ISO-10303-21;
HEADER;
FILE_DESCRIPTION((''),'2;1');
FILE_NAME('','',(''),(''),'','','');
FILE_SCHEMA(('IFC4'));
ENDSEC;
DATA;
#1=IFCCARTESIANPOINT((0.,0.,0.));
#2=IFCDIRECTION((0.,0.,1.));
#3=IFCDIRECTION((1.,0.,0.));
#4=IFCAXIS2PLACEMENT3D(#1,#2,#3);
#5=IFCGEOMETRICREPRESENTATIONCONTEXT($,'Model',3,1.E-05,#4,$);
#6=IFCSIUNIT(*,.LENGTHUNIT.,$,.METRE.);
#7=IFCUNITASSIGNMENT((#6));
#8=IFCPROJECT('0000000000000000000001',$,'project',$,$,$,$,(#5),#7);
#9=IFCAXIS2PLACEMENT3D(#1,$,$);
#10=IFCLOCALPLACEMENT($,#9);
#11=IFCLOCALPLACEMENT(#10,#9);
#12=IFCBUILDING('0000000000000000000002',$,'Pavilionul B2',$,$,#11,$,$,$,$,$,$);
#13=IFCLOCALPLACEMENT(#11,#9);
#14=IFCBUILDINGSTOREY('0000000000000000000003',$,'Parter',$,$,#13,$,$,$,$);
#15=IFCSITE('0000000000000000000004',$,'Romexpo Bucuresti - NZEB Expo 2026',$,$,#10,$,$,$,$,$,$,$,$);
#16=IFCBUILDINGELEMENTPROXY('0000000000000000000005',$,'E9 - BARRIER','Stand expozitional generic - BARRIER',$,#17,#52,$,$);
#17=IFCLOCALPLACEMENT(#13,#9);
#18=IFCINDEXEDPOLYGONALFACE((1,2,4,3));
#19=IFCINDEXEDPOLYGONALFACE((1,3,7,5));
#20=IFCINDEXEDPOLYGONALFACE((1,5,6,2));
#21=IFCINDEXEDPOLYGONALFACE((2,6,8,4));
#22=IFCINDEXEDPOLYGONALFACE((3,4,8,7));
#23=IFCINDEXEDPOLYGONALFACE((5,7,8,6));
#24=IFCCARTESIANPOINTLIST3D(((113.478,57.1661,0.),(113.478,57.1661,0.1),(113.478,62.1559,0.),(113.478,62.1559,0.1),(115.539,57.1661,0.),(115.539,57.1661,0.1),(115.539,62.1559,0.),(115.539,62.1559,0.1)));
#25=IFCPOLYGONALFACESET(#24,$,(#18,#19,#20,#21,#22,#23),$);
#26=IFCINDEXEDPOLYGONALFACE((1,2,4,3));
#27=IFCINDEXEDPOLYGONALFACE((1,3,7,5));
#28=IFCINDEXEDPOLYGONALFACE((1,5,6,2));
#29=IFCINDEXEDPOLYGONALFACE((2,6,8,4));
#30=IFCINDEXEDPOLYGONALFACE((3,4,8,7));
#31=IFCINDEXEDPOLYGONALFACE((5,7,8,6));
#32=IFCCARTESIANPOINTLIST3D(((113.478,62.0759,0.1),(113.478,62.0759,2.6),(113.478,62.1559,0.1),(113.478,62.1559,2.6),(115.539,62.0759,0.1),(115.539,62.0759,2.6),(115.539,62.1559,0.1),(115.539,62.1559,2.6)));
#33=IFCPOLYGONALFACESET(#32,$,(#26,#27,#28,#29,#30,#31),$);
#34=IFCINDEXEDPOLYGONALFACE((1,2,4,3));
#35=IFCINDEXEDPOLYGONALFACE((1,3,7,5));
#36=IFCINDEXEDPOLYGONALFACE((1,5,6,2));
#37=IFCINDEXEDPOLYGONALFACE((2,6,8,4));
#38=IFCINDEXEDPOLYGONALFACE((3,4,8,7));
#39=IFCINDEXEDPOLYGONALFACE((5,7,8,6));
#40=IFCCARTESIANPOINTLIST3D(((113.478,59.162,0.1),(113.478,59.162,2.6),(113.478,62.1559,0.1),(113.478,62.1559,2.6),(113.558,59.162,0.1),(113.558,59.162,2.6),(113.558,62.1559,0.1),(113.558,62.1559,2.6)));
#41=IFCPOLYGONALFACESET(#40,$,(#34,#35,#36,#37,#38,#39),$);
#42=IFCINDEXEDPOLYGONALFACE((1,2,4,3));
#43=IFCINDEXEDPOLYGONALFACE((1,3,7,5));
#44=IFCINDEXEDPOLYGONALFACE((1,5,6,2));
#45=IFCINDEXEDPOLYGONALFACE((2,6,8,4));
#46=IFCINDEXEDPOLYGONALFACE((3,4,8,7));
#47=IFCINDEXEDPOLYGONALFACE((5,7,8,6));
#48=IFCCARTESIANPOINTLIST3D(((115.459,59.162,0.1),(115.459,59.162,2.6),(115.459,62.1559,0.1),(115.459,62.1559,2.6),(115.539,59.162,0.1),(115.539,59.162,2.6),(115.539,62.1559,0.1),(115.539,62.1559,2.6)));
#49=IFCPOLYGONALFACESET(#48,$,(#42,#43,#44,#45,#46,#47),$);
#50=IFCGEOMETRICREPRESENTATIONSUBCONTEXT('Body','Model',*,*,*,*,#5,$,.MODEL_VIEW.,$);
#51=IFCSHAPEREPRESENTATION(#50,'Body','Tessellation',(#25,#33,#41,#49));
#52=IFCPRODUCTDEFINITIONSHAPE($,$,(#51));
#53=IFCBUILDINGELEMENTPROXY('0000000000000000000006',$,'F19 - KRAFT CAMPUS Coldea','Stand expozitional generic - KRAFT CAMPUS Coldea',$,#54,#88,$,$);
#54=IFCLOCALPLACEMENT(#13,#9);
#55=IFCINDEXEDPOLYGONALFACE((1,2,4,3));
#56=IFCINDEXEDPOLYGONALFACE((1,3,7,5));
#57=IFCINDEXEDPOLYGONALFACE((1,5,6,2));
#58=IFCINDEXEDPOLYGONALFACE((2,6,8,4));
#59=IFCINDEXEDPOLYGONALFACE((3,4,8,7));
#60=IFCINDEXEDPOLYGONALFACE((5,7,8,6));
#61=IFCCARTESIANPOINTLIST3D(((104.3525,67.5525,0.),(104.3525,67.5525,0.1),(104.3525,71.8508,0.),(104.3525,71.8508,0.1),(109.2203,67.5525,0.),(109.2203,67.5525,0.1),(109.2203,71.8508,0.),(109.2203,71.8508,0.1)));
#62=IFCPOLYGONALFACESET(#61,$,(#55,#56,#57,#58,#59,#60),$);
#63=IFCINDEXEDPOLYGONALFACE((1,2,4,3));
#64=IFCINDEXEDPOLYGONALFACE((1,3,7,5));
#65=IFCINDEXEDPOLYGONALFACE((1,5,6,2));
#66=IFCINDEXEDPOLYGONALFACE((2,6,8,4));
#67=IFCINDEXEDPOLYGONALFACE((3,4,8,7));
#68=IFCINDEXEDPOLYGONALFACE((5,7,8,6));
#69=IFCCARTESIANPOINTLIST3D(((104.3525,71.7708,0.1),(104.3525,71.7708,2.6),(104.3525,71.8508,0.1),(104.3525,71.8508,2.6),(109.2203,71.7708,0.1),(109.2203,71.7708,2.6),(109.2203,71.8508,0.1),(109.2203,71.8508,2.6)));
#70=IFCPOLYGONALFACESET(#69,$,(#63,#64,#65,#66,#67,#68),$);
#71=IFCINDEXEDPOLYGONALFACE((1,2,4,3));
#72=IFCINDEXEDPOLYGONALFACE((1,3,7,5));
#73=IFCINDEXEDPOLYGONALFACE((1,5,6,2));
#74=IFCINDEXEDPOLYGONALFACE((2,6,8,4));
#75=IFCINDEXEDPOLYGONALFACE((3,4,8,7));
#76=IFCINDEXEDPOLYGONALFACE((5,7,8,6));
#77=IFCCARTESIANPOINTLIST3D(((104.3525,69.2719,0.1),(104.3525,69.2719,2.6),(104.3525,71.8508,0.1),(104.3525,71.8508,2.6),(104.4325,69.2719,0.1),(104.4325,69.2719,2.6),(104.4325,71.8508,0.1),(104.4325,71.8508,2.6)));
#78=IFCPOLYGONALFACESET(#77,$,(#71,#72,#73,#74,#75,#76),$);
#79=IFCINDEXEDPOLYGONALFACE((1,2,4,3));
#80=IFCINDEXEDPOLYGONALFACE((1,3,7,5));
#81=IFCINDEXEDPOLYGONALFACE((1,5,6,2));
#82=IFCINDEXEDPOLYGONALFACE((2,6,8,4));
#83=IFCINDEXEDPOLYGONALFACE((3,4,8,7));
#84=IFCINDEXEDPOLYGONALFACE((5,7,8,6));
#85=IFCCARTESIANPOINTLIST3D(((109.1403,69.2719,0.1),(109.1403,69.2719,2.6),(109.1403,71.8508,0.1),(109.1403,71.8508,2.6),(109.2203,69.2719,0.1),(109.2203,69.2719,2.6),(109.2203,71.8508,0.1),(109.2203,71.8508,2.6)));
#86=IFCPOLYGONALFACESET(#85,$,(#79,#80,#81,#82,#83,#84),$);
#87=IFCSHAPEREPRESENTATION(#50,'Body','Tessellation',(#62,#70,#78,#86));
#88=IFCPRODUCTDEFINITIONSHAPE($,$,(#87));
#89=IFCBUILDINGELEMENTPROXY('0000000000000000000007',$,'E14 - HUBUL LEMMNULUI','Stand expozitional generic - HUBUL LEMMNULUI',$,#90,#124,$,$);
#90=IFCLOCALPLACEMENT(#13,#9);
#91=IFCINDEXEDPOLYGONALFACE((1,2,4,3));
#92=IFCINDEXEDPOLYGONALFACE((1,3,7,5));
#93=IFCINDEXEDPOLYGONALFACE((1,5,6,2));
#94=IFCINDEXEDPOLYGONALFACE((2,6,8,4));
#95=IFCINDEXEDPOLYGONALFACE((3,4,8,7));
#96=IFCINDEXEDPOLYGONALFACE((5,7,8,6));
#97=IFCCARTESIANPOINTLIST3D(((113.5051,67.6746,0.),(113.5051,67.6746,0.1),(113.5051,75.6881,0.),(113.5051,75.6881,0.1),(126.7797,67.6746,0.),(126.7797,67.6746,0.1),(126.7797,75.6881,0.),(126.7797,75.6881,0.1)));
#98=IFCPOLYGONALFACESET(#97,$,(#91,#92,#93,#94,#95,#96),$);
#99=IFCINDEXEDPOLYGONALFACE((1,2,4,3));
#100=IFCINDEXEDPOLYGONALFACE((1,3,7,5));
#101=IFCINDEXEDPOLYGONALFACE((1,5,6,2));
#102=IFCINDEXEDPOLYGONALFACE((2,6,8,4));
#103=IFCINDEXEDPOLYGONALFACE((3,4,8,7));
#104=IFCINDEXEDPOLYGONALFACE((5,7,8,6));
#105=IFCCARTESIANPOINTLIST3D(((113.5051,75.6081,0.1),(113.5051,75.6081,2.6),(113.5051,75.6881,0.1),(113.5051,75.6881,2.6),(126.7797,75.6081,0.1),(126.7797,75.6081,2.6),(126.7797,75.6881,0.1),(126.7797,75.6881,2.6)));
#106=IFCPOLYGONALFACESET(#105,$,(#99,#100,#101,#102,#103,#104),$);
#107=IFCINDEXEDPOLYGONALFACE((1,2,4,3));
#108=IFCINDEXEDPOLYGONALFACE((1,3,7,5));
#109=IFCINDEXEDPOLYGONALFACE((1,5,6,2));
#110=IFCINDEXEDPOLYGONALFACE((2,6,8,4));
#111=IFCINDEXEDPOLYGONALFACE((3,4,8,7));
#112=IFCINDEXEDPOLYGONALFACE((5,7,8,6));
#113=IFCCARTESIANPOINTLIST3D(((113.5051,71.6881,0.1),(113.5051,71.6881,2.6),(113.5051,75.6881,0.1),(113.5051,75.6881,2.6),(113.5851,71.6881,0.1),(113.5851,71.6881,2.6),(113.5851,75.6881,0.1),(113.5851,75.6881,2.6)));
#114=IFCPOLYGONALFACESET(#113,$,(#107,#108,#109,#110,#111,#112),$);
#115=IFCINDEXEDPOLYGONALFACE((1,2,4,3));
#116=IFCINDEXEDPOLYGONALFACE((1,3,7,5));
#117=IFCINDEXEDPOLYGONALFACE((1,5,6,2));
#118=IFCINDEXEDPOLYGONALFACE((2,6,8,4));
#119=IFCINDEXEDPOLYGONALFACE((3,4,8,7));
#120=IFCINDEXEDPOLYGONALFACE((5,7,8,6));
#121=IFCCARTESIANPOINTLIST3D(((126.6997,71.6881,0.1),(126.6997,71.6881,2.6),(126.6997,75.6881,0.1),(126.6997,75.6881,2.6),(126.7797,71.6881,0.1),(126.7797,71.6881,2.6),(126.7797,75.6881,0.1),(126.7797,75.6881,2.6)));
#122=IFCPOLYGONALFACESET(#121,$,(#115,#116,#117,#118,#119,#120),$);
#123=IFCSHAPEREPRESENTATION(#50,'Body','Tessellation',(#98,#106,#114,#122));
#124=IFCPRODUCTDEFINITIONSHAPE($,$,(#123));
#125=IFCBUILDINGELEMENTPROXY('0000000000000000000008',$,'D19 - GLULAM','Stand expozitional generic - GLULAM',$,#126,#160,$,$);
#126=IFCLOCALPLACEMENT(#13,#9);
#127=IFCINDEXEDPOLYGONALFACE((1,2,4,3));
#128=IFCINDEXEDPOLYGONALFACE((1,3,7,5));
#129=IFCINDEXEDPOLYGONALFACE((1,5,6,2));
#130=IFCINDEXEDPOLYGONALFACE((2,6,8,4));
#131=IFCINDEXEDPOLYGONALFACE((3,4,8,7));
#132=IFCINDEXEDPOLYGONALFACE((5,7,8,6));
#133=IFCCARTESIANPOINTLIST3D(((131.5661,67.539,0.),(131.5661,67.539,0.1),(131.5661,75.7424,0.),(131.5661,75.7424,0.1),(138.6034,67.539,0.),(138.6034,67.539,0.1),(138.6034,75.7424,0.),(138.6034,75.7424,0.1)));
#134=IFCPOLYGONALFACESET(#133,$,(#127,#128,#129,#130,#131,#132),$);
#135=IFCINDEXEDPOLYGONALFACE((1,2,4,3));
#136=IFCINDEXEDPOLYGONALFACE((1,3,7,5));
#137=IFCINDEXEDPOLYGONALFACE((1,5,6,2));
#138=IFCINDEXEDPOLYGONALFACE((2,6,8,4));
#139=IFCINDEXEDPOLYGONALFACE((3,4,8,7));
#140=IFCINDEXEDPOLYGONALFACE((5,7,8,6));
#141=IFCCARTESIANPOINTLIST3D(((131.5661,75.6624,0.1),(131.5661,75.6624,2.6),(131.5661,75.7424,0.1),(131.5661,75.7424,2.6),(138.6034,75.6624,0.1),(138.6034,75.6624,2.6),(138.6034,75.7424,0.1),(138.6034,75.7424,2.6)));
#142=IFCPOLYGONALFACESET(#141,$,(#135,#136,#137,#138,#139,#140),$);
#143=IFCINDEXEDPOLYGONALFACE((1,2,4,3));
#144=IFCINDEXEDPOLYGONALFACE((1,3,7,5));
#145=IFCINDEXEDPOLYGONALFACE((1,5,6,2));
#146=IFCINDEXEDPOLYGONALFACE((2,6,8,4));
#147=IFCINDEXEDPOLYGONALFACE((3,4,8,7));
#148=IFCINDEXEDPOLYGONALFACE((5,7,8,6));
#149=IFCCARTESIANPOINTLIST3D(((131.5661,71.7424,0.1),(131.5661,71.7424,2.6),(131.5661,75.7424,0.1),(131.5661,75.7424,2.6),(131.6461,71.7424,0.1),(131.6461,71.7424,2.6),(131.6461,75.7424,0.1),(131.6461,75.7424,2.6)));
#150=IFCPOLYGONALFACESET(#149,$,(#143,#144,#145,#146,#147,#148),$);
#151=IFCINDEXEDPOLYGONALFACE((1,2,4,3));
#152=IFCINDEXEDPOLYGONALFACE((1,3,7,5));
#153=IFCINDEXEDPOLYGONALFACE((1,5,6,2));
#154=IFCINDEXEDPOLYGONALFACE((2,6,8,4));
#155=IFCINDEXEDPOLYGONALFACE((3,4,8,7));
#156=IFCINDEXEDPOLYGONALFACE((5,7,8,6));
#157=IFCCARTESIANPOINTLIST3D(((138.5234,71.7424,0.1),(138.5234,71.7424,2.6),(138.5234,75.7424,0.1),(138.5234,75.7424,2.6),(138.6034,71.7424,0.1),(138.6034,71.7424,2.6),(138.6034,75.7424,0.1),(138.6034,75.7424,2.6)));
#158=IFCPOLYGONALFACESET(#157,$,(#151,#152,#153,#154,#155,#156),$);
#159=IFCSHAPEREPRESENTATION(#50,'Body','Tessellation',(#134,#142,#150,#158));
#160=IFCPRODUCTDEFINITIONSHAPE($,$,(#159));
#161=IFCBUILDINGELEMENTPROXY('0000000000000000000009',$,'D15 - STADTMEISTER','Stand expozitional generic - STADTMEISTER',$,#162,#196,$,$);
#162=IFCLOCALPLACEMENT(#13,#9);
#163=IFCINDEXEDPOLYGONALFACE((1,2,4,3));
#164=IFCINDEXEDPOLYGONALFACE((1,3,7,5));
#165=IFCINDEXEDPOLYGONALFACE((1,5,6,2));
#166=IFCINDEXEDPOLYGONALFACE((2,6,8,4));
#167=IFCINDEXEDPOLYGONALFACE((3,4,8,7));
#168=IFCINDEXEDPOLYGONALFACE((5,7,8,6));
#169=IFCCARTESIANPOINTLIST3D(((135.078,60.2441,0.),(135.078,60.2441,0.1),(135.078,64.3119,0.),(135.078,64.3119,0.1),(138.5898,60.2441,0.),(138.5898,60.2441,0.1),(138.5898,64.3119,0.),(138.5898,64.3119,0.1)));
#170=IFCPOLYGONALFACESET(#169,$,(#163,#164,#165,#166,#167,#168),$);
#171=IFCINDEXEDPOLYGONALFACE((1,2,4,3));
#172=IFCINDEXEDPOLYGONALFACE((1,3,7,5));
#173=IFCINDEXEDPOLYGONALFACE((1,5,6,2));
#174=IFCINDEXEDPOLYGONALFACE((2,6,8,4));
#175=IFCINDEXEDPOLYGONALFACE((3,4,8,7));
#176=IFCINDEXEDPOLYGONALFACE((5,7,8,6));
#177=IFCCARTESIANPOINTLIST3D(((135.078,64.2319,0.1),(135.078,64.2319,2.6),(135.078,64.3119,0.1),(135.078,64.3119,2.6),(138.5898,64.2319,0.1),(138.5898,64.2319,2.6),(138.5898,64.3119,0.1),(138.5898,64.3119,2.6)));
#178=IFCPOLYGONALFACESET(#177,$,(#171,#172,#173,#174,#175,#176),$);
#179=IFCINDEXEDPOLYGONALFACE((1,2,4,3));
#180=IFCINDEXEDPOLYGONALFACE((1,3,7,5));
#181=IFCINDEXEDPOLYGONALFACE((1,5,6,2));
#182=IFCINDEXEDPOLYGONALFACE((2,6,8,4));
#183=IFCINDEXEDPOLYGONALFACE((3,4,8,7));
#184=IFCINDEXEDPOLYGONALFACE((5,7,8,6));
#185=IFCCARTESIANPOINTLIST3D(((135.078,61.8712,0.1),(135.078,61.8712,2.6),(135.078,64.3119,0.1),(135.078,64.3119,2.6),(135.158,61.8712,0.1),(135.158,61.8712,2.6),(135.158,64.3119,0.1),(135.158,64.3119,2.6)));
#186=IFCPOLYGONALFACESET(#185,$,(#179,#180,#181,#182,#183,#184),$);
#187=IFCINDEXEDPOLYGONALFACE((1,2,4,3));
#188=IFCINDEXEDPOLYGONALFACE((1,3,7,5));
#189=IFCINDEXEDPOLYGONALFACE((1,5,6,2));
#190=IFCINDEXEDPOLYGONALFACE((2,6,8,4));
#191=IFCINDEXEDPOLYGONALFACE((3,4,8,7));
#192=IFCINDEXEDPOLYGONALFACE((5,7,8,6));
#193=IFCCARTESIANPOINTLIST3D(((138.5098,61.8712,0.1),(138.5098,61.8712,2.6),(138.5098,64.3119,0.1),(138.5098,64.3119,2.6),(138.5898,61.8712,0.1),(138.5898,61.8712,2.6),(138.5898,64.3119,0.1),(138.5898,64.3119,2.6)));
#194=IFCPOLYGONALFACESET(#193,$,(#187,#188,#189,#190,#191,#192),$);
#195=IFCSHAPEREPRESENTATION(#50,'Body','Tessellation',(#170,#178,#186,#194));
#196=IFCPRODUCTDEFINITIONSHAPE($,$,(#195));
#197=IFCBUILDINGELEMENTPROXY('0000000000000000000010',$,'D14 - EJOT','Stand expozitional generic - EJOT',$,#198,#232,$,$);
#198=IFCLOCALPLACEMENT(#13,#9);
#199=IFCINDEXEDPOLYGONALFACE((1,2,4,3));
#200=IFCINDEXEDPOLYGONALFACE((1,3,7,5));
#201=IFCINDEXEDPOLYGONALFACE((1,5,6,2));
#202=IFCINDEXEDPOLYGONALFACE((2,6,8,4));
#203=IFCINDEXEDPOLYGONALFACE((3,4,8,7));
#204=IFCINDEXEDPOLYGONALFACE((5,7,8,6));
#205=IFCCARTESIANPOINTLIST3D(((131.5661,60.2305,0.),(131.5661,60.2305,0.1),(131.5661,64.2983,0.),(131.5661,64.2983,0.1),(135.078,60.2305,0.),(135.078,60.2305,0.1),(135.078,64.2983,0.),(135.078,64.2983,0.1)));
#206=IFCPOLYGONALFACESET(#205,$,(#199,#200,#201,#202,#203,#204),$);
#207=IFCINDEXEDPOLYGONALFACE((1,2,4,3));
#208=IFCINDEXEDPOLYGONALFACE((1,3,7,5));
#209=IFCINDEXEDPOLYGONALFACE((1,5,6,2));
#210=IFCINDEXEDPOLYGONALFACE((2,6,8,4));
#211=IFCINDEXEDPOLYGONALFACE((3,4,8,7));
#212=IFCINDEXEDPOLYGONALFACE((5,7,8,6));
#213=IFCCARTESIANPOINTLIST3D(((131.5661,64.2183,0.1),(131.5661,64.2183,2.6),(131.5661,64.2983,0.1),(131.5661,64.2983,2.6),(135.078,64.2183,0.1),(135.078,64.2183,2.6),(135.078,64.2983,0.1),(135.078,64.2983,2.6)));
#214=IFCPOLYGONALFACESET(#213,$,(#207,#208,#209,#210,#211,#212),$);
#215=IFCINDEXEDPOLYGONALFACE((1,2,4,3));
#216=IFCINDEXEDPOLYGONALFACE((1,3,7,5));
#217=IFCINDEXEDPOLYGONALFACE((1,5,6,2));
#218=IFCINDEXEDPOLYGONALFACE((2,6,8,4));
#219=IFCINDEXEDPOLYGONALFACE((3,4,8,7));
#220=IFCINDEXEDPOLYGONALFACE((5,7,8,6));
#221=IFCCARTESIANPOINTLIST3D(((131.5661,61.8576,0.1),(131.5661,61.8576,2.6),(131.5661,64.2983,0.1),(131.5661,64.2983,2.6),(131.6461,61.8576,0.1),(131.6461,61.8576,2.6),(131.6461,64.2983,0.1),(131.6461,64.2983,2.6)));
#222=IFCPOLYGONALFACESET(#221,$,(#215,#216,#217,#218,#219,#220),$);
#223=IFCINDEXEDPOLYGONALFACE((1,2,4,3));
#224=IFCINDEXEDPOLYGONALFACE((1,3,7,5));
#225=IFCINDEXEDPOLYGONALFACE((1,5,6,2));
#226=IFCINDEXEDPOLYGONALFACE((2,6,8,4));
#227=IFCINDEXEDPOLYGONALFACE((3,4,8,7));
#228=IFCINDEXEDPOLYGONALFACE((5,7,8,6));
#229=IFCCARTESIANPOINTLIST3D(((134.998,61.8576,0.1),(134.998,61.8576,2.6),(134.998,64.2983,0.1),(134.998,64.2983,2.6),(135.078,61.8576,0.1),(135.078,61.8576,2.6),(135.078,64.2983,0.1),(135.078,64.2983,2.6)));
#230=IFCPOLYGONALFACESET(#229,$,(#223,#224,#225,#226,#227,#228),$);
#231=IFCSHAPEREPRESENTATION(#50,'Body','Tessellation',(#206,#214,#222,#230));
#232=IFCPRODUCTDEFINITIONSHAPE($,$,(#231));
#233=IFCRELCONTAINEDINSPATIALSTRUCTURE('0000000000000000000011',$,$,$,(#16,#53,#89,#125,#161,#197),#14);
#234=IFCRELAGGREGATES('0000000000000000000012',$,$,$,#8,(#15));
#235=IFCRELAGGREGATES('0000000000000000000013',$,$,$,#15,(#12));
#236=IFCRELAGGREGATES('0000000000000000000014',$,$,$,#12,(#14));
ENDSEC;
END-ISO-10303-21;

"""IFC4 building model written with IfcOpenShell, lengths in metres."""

from ifc_helpers import new_model, si_unit, frame, frame_2d, origin, origin_with_axes, place, context, subcontext, project, spatial, rectangle, extrude, element, save


model = new_model("IFC4")

# Units and contexts
model_context = context("Model", 3, precision=1e-05, world=origin_with_axes())
body_context = subcontext(model_context, "Body", "Model", "MODEL_VIEW")
ifc_project = project(units=[si_unit("LENGTHUNIT", "METRE")], contexts=[model_context])

# Site, building, storey
site_placement = place(None, origin())
site = spatial("IfcSite", under=ifc_project, at=site_placement, Name="Romexpo Bucuresti - NZEB Expo 2026")
building_placement = place(site_placement, origin())
building = spatial("IfcBuilding", under=site, at=building_placement, Name="Pavilionul B2")
storey_placement = place(building_placement, origin())
storey = spatial("IfcBuildingStorey", under=building, at=storey_placement, Name="Parter")

# Building element proxies
proxy_1_placement = place(storey_placement, frame((113.478, 57.1661, 0.0), z_axis=(0.0, 0.0, 1.0), x_axis=(1.0, 0.0, 0.0)))
element("IfcBuildingElementProxy", 1, at=proxy_1_placement, inside=storey, Name="E9 - BARRIER", Description="Stand expozitional generic - BARRIER", context=body_context, shape_type="SweptSolid", body=[
    extrude(rectangle(XDim=2.061, YDim=4.9898, at=frame_2d((1.0305, 2.4949))), origin(), (0.0, 0.0, 1.0), 0.1),
    extrude(rectangle(XDim=2.061, YDim=0.08, at=frame_2d((1.0305, 4.9498))), frame((0.0, 0.0, 0.1)), (0.0, 0.0, 1.0), 2.5),
    extrude(rectangle(XDim=0.08, YDim=2.9939, at=frame_2d((0.04, 3.4929))), frame((0.0, 0.0, 0.1)), (0.0, 0.0, 1.0), 2.5),
    extrude(rectangle(XDim=0.08, YDim=2.9939, at=frame_2d((2.021, 3.4929))), frame((0.0, 0.0, 0.1)), (0.0, 0.0, 1.0), 2.5),
])
proxy_2_placement = place(storey_placement, frame((104.3525, 67.5525, 0.0), z_axis=(0.0, 0.0, 1.0), x_axis=(1.0, 0.0, 0.0)))
element("IfcBuildingElementProxy", 2, at=proxy_2_placement, inside=storey, Name="F19 - KRAFT CAMPUS Coldea", Description="Stand expozitional generic - KRAFT CAMPUS Coldea", context=body_context, shape_type="SweptSolid", body=[
    extrude(rectangle(XDim=4.8678, YDim=4.2983, at=frame_2d((2.4339, 2.1492))), origin(), (0.0, 0.0, 1.0), 0.1),
    extrude(rectangle(XDim=4.8678, YDim=0.08, at=frame_2d((2.4339, 4.2583))), frame((0.0, 0.0, 0.1)), (0.0, 0.0, 1.0), 2.5),
    extrude(rectangle(XDim=0.08, YDim=2.579, at=frame_2d((0.04, 3.0088))), frame((0.0, 0.0, 0.1)), (0.0, 0.0, 1.0), 2.5),
    extrude(rectangle(XDim=0.08, YDim=2.579, at=frame_2d((4.8278, 3.0088))), frame((0.0, 0.0, 0.1)), (0.0, 0.0, 1.0), 2.5),
])
proxy_3_placement = place(storey_placement, frame((113.5051, 67.6746, 0.0), z_axis=(0.0, 0.0, 1.0), x_axis=(1.0, 0.0, 0.0)))
element("IfcBuildingElementProxy", 3, at=proxy_3_placement, inside=storey, Name="E14 - HUBUL LEMMNULUI", Description="Stand expozitional generic - HUBUL LEMMNULUI", context=body_context, shape_type="SweptSolid", body=[
    extrude(rectangle(XDim=13.2746, YDim=8.0136, at=frame_2d((6.6373, 4.0068))), origin(), (0.0, 0.0, 1.0), 0.1),
    extrude(rectangle(XDim=13.2746, YDim=0.08, at=frame_2d((6.6373, 7.9736))), frame((0.0, 0.0, 0.1)), (0.0, 0.0, 1.0), 2.5),
    extrude(rectangle(XDim=0.08, YDim=4.0, at=frame_2d((0.04, 6.0136))), frame((0.0, 0.0, 0.1)), (0.0, 0.0, 1.0), 2.5),
    extrude(rectangle(XDim=0.08, YDim=4.0, at=frame_2d((13.2346, 6.0136))), frame((0.0, 0.0, 0.1)), (0.0, 0.0, 1.0), 2.5),
])
proxy_4_placement = place(storey_placement, frame((131.5661, 67.539, 0.0), z_axis=(0.0, 0.0, 1.0), x_axis=(1.0, 0.0, 0.0)))
element("IfcBuildingElementProxy", 4, at=proxy_4_placement, inside=storey, Name="D19 - GLULAM", Description="Stand expozitional generic - GLULAM", context=body_context, shape_type="SweptSolid", body=[
    extrude(rectangle(XDim=7.0373, YDim=8.2034, at=frame_2d((3.5186, 4.1017))), origin(), (0.0, 0.0, 1.0), 0.1),
    extrude(rectangle(XDim=7.0373, YDim=0.08, at=frame_2d((3.5186, 8.1634))), frame((0.0, 0.0, 0.1)), (0.0, 0.0, 1.0), 2.5),
    extrude(rectangle(XDim=0.08, YDim=4.0, at=frame_2d((0.04, 6.2034))), frame((0.0, 0.0, 0.1)), (0.0, 0.0, 1.0), 2.5),
    extrude(rectangle(XDim=0.08, YDim=4.0, at=frame_2d((6.9973, 6.2034))), frame((0.0, 0.0, 0.1)), (0.0, 0.0, 1.0), 2.5),
])
for number, where, z_axis, x_axis, name, description in (
    (5, (135.078, 60.2441, 0.0), (0.0, 0.0, 1.0), (1.0, 0.0, 0.0), "D15 - STADTMEISTER", "Stand expozitional generic - STADTMEISTER"),
    (6, (131.5661, 60.2305, 0.0), (0.0, 0.0, 1.0), (1.0, 0.0, 0.0), "D14 - EJOT", "Stand expozitional generic - EJOT"),
):
    element("IfcBuildingElementProxy", number, at=place(storey_placement, frame(where, z_axis=z_axis, x_axis=x_axis)), inside=storey, Name=name, Description=description, context=body_context, shape_type="SweptSolid", body=[
        extrude(rectangle(XDim=3.5119, YDim=4.0678, at=frame_2d((1.7559, 2.0339))), origin(), (0.0, 0.0, 1.0), 0.1),
        extrude(rectangle(XDim=3.5119, YDim=0.08, at=frame_2d((1.7559, 4.0278))), frame((0.0, 0.0, 0.1)), (0.0, 0.0, 1.0), 2.5),
        extrude(rectangle(XDim=0.08, YDim=2.4407, at=frame_2d((0.04, 2.8475))), frame((0.0, 0.0, 0.1)), (0.0, 0.0, 1.0), 2.5),
        extrude(rectangle(XDim=0.08, YDim=2.4407, at=frame_2d((3.4719, 2.8475))), frame((0.0, 0.0, 0.1)), (0.0, 0.0, 1.0), 2.5),
    ])

save(model, "model.ifc")
